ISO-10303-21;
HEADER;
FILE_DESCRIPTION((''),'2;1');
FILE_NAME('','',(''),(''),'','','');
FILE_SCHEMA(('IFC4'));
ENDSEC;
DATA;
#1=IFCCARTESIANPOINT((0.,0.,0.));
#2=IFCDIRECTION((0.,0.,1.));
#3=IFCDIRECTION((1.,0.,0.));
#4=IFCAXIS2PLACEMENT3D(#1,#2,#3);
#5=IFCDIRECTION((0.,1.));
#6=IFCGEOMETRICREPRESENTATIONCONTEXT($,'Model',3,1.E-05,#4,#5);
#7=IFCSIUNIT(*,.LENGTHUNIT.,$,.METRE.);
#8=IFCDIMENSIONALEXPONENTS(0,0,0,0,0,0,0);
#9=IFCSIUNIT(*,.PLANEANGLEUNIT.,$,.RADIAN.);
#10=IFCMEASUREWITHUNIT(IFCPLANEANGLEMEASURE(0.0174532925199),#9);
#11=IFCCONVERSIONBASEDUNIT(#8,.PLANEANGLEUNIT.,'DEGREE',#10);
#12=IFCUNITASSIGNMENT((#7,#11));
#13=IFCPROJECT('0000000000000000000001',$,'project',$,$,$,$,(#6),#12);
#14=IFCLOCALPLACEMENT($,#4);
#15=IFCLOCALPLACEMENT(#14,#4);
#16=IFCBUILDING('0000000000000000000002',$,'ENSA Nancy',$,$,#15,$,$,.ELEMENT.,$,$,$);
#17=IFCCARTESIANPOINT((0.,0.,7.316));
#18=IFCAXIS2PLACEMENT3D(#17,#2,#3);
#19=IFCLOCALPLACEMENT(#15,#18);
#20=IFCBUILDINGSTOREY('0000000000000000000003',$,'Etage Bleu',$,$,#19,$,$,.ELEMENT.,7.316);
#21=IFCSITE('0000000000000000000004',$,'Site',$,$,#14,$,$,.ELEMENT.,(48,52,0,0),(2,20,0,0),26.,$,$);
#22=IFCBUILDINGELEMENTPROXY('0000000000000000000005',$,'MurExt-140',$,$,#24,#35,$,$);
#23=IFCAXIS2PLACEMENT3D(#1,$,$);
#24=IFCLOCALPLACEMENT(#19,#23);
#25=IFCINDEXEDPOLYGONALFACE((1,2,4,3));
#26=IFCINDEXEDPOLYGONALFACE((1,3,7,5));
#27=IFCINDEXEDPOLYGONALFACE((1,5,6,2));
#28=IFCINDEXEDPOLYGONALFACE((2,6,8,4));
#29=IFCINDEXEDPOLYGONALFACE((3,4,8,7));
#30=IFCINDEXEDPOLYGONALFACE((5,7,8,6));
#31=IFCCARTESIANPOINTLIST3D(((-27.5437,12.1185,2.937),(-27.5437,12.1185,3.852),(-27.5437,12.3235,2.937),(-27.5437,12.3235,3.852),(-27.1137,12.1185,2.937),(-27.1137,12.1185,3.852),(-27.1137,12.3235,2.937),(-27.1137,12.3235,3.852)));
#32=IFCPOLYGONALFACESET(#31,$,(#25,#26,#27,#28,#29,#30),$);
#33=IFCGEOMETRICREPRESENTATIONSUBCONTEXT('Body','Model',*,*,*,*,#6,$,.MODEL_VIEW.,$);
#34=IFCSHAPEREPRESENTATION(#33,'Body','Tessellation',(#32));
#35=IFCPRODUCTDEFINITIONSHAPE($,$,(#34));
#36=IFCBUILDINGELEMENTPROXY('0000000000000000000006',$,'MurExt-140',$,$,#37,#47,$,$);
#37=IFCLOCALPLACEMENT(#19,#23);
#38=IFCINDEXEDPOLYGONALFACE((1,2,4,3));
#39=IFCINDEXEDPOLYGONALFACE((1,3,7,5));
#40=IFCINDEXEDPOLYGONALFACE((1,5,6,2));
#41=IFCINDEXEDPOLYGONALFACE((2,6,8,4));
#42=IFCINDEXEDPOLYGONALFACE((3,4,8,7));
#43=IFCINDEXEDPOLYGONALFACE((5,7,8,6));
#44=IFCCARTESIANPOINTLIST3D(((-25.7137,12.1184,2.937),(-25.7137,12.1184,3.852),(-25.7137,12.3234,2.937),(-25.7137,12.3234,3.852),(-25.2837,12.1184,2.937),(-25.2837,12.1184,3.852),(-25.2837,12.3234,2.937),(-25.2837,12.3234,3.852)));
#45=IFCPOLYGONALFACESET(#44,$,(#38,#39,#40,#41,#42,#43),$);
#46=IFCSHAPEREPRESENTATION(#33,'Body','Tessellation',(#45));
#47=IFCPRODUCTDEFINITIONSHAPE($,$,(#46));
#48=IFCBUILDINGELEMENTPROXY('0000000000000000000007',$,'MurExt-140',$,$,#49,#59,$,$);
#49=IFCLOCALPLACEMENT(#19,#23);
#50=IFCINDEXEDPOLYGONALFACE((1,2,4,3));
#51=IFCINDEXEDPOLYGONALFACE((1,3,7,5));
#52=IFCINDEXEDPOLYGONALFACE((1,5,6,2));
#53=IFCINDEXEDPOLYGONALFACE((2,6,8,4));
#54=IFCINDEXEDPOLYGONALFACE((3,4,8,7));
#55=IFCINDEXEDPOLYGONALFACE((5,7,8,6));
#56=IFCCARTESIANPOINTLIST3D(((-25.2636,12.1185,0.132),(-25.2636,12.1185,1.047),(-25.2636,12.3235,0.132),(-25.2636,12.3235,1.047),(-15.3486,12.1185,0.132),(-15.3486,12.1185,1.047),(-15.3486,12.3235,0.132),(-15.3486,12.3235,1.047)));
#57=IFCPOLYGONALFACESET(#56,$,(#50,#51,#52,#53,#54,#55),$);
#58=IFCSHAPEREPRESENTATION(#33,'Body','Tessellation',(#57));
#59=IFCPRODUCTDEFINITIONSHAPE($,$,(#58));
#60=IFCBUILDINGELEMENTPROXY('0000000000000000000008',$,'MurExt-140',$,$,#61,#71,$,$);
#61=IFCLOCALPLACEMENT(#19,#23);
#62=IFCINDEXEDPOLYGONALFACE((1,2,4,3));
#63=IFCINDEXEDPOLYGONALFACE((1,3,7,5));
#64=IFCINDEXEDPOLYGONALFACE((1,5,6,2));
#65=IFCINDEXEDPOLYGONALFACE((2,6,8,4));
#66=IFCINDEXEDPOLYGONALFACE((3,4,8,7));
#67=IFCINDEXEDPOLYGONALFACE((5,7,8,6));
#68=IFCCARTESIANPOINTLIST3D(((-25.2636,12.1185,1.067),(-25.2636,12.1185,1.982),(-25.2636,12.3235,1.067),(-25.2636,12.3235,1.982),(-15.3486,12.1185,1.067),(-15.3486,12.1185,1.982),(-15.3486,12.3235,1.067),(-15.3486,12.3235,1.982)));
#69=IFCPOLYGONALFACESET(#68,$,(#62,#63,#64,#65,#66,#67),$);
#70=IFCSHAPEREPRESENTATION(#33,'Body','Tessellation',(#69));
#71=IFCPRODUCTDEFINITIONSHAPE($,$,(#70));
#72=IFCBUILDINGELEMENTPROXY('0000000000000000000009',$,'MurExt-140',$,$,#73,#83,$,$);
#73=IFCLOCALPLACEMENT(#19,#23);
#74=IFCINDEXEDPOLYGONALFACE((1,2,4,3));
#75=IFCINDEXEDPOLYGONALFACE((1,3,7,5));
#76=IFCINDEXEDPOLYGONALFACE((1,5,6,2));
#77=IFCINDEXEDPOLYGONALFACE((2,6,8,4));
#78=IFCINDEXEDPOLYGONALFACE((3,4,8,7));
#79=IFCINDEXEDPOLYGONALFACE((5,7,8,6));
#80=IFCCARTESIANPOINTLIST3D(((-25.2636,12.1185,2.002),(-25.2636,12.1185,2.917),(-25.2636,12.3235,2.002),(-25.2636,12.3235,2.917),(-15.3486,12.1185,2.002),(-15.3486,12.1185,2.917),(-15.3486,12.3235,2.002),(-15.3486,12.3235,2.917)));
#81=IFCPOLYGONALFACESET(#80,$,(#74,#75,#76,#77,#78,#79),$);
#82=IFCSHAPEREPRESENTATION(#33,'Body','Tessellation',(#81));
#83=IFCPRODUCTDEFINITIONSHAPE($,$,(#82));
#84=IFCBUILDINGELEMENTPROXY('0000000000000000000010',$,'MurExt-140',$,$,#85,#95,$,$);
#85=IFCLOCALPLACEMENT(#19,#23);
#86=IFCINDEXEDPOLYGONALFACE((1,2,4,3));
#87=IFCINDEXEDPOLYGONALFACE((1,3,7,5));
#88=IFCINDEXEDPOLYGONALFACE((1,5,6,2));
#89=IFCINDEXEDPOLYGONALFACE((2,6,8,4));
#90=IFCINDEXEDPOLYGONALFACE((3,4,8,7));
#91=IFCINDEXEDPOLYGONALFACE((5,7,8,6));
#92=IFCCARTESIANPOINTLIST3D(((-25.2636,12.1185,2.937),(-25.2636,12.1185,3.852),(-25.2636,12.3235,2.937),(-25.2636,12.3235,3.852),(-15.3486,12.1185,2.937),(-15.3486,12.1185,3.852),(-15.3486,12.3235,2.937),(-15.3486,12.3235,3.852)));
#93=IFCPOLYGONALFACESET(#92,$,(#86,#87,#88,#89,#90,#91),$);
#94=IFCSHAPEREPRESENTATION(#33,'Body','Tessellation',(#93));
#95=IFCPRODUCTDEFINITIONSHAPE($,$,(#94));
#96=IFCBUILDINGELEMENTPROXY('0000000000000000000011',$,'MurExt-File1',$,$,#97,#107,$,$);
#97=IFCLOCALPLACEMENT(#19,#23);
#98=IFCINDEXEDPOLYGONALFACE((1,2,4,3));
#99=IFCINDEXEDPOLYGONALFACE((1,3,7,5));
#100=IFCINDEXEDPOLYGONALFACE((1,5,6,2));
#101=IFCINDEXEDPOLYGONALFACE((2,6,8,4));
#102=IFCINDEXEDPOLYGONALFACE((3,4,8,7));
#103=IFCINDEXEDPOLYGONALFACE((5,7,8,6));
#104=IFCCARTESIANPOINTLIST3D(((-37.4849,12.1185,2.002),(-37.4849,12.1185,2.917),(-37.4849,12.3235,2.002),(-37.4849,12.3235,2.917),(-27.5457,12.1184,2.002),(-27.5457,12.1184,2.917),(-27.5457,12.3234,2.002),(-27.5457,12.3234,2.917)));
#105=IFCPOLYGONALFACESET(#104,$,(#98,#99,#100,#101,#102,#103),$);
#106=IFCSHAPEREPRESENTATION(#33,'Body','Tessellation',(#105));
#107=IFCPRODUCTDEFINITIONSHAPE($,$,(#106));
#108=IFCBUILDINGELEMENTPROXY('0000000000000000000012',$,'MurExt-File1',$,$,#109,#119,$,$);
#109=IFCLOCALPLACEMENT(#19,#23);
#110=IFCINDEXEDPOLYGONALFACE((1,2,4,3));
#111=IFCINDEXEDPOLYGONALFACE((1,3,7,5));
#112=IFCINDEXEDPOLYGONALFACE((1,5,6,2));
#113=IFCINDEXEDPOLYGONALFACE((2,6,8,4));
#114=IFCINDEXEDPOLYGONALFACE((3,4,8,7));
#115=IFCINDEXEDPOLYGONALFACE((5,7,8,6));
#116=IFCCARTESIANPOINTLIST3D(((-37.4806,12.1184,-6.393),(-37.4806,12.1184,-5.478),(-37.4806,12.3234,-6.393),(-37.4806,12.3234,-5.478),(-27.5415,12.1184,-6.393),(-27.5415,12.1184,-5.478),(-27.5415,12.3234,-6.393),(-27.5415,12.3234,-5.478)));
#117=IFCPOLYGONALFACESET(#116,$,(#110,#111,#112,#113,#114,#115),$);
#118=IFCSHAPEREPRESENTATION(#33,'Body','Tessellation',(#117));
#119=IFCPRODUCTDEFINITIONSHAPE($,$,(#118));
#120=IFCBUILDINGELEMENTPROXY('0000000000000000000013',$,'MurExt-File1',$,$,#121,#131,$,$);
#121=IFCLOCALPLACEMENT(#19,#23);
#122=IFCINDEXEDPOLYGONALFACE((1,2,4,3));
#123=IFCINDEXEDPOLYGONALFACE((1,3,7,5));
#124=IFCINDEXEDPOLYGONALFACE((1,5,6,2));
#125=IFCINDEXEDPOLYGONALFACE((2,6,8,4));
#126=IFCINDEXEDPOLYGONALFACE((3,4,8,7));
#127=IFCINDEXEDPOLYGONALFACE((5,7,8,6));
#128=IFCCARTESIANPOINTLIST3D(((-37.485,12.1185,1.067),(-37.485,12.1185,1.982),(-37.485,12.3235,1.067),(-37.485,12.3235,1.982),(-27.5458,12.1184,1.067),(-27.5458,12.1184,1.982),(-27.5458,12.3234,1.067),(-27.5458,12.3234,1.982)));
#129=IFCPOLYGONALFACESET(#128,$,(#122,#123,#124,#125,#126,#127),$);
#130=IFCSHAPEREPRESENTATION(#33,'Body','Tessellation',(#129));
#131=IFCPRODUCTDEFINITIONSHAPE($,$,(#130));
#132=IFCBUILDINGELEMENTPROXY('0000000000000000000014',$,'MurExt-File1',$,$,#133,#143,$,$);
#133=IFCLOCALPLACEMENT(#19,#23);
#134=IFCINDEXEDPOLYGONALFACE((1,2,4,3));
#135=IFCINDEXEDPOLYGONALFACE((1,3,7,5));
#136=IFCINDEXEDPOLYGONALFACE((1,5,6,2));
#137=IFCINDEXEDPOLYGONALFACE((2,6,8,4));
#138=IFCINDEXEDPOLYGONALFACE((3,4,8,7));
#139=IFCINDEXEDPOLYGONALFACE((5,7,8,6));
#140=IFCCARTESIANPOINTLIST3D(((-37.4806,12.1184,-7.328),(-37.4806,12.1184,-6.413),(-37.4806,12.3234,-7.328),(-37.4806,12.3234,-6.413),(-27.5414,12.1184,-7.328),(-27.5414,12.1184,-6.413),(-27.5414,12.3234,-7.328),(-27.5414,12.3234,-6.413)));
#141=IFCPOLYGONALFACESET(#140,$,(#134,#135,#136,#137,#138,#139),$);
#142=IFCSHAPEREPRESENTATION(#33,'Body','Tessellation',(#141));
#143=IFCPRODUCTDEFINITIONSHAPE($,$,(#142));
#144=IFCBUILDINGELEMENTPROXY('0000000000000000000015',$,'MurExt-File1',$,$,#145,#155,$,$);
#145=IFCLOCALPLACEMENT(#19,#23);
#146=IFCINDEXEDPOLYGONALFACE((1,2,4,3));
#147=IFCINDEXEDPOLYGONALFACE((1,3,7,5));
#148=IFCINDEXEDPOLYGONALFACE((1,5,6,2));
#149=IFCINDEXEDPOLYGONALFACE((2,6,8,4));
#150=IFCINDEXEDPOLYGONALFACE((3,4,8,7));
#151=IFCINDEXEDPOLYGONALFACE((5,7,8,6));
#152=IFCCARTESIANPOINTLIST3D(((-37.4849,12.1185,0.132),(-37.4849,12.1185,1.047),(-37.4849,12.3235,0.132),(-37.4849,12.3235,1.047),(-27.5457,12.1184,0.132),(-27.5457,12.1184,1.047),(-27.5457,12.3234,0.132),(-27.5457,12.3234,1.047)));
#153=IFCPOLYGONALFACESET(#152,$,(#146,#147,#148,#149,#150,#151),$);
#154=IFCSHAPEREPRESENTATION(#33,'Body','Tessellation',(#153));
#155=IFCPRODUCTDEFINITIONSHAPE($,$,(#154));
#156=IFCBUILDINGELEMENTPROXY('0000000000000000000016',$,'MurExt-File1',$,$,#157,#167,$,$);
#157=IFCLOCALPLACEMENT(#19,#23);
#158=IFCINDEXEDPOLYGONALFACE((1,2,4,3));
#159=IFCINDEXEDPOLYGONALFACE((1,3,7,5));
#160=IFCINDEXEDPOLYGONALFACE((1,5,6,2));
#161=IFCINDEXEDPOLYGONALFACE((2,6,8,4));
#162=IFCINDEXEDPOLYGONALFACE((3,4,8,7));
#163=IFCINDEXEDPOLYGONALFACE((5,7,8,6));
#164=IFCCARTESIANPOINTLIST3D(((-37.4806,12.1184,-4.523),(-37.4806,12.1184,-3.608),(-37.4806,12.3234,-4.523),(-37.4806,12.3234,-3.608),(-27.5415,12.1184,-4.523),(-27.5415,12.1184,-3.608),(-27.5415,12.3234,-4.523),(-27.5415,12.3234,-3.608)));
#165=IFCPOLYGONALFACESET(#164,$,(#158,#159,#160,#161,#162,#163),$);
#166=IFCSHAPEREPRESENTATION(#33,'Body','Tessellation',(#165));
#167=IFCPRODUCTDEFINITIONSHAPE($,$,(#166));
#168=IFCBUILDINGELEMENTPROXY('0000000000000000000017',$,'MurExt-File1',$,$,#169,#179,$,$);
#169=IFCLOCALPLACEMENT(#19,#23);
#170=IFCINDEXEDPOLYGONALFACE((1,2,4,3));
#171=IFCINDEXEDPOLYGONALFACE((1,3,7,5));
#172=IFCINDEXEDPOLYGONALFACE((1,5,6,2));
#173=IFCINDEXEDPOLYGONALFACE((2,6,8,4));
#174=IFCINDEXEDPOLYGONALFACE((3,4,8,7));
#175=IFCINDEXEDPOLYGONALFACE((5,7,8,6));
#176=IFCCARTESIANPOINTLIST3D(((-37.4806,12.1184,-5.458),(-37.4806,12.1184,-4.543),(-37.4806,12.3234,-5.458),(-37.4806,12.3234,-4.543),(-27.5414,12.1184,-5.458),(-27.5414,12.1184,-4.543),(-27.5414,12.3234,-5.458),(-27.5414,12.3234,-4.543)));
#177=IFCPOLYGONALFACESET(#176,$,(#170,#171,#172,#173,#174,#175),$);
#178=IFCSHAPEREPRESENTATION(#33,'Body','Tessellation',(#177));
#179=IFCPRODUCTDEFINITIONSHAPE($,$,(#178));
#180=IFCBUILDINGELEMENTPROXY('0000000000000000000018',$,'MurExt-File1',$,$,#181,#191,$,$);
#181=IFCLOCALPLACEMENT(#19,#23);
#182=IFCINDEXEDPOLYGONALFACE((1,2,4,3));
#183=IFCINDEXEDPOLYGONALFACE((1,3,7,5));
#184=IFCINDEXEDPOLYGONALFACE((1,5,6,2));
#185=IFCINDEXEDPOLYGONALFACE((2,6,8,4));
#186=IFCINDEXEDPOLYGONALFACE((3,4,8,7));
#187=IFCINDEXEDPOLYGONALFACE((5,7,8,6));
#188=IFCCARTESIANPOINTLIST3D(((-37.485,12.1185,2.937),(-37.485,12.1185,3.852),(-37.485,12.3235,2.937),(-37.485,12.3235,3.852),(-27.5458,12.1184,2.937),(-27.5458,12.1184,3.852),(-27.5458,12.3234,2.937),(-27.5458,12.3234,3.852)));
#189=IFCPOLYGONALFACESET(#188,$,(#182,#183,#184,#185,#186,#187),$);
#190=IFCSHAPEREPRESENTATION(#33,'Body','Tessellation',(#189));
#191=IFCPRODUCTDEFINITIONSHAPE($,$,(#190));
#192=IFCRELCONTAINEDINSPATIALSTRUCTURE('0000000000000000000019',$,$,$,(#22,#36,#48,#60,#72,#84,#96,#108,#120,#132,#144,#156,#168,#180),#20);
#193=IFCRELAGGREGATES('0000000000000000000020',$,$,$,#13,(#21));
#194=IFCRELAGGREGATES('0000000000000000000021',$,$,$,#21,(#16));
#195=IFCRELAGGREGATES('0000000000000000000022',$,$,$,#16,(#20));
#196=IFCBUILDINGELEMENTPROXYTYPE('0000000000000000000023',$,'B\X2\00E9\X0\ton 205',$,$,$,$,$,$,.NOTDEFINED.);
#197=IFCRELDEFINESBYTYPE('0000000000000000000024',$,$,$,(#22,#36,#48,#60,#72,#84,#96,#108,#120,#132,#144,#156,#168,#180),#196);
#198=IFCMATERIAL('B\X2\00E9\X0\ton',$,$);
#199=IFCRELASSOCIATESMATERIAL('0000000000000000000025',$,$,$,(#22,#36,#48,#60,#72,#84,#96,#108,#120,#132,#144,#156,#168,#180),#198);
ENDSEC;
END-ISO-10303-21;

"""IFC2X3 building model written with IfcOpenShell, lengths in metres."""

from ifc_helpers import new_model, entity, si_unit, converted_unit, direction, frame, origin_with_axes, place, context, subcontext, project, spatial, polyline, outline, extrude, material, type_object, element, save


model = new_model("IFC2X3")

# Units and contexts
model_context = context("Model", 3, precision=1e-05, world=origin_with_axes(), true_north=direction((0.0, 1.0)))
body_context = subcontext(model_context, "Body", "Model", "MODEL_VIEW")
ifc_project = project(units=[si_unit("LENGTHUNIT", "METRE"), converted_unit("PLANEANGLEUNIT", "DEGREE", entity("IfcPlaneAngleMeasure", 0.0174532925199), si_unit("PLANEANGLEUNIT", "RADIAN"), dimensions=[0, 0, 0, 0, 0, 0, 0])], contexts=[model_context])

# Site, building, storey
site_placement = place(None, origin_with_axes())
site = spatial("IfcSite", under=ifc_project, at=site_placement, Name="Site", CompositionType="ELEMENT", RefLatitude=(48, 52, 0, 0), RefLongitude=(2, 20, 0, 0), RefElevation=26.0)
building_placement = place(site_placement, origin_with_axes())
building = spatial("IfcBuilding", under=site, at=building_placement, Name="ENSA Nancy", CompositionType="ELEMENT")
storey_placement = place(building_placement, frame((0.0, 0.0, 7.316), z_axis=(0.0, 0.0, 1.0), x_axis=(1.0, 0.0, 0.0)))
storey = spatial("IfcBuildingStorey", under=building, at=storey_placement, Name="Etage Bleu", CompositionType="ELEMENT", Elevation=7.316)

# Shared definitions
ifc_material_1 = material(Name="Béton")

# Building element proxies
building_element_proxy_type_1 = type_object("IfcBuildingElementProxyType", Name="Béton 205", PredefinedType="NOTDEFINED")
for number, where, z_axis, x_axis, name in (
    (1, (-27.5437, 12.3235, 2.937), (0.0, 0.0, 1.0), (1.0, 0.0, 0.0), "MurExt-140"),
    (2, (-25.7137, 12.3234, 2.937), (0.0, 0.0, 1.0), (1.0, 0.0, 0.0), "MurExt-140"),
):
    element("IfcBuildingElementProxy", number, at=place(storey_placement, frame(where, z_axis=z_axis, x_axis=x_axis)), inside=storey, type_object=building_element_proxy_type_1, material=ifc_material_1, Name=name, context=body_context, shape_type="SweptSolid", body=[
        extrude(outline(polyline([(0.0, -0.205), (0.43, -0.205), (0.43, 0.0), (0.0, 0.0), (0.0, -0.205)])), origin_with_axes(), (0.0, 0.0, 1.0), 0.915),
    ])
for number, where, z_axis, x_axis, name in (
    (3, (-25.2636, 12.3235, 0.132), (0.0, 0.0, 1.0), (1.0, 0.0, 0.0), "MurExt-140"),
    (4, (-25.2636, 12.3235, 1.067), (0.0, 0.0, 1.0), (1.0, 0.0, 0.0), "MurExt-140"),
    (5, (-25.2636, 12.3235, 2.002), (0.0, 0.0, 1.0), (1.0, 0.0, 0.0), "MurExt-140"),
    (6, (-25.2636, 12.3235, 2.937), (0.0, 0.0, 1.0), (1.0, 0.0, 0.0), "MurExt-140"),
):
    element("IfcBuildingElementProxy", number, at=place(storey_placement, frame(where, z_axis=z_axis, x_axis=x_axis)), inside=storey, type_object=building_element_proxy_type_1, material=ifc_material_1, Name=name, context=body_context, shape_type="SweptSolid", body=[
        extrude(outline(polyline([(0.0, -0.205), (9.915, -0.205), (9.915, 0.0), (0.0, 0.0), (0.0, -0.205)])), origin_with_axes(), (0.0, 0.0, 1.0), 0.915),
    ])
for number, where, z_axis, x_axis, name in (
    (7, (-37.4849, 12.3235, 2.002), (0.0, 0.0, 1.0), (1.0, -0.000005, 0.0), "MurExt-File1"),
    (8, (-37.4806, 12.3234, -6.393), (0.0, 0.0, 1.0), (1.0, -0.000005, 0.0), "MurExt-File1"),
    (9, (-37.485, 12.3235, 1.067), (0.0, 0.0, 1.0), (1.0, -0.000005, 0.0), "MurExt-File1"),
    (10, (-37.4806, 12.3234, -7.328), (0.0, 0.0, 1.0), (1.0, -0.000005, 0.0), "MurExt-File1"),
    (11, (-37.4849, 12.3235, 0.132), (0.0, 0.0, 1.0), (1.0, -0.000005, 0.0), "MurExt-File1"),
    (12, (-37.4806, 12.3234, -4.523), (0.0, 0.0, 1.0), (1.0, -0.000005, 0.0), "MurExt-File1"),
    (13, (-37.4806, 12.3234, -5.458), (0.0, 0.0, 1.0), (1.0, -0.000005, 0.0), "MurExt-File1"),
    (14, (-37.485, 12.3235, 2.937), (0.0, 0.0, 1.0), (1.0, -0.000005, 0.0), "MurExt-File1"),
):
    element("IfcBuildingElementProxy", number, at=place(storey_placement, frame(where, z_axis=z_axis, x_axis=x_axis)), inside=storey, type_object=building_element_proxy_type_1, material=ifc_material_1, Name=name, context=body_context, shape_type="SweptSolid", body=[
        extrude(outline(polyline([(0.0, -0.205), (9.9392, -0.205), (9.9392, 0.0), (0.0, 0.0), (0.0, -0.205)])), origin_with_axes(), (0.0, 0.0, 1.0), 0.915),
    ])

save(model, "model.ifc")
